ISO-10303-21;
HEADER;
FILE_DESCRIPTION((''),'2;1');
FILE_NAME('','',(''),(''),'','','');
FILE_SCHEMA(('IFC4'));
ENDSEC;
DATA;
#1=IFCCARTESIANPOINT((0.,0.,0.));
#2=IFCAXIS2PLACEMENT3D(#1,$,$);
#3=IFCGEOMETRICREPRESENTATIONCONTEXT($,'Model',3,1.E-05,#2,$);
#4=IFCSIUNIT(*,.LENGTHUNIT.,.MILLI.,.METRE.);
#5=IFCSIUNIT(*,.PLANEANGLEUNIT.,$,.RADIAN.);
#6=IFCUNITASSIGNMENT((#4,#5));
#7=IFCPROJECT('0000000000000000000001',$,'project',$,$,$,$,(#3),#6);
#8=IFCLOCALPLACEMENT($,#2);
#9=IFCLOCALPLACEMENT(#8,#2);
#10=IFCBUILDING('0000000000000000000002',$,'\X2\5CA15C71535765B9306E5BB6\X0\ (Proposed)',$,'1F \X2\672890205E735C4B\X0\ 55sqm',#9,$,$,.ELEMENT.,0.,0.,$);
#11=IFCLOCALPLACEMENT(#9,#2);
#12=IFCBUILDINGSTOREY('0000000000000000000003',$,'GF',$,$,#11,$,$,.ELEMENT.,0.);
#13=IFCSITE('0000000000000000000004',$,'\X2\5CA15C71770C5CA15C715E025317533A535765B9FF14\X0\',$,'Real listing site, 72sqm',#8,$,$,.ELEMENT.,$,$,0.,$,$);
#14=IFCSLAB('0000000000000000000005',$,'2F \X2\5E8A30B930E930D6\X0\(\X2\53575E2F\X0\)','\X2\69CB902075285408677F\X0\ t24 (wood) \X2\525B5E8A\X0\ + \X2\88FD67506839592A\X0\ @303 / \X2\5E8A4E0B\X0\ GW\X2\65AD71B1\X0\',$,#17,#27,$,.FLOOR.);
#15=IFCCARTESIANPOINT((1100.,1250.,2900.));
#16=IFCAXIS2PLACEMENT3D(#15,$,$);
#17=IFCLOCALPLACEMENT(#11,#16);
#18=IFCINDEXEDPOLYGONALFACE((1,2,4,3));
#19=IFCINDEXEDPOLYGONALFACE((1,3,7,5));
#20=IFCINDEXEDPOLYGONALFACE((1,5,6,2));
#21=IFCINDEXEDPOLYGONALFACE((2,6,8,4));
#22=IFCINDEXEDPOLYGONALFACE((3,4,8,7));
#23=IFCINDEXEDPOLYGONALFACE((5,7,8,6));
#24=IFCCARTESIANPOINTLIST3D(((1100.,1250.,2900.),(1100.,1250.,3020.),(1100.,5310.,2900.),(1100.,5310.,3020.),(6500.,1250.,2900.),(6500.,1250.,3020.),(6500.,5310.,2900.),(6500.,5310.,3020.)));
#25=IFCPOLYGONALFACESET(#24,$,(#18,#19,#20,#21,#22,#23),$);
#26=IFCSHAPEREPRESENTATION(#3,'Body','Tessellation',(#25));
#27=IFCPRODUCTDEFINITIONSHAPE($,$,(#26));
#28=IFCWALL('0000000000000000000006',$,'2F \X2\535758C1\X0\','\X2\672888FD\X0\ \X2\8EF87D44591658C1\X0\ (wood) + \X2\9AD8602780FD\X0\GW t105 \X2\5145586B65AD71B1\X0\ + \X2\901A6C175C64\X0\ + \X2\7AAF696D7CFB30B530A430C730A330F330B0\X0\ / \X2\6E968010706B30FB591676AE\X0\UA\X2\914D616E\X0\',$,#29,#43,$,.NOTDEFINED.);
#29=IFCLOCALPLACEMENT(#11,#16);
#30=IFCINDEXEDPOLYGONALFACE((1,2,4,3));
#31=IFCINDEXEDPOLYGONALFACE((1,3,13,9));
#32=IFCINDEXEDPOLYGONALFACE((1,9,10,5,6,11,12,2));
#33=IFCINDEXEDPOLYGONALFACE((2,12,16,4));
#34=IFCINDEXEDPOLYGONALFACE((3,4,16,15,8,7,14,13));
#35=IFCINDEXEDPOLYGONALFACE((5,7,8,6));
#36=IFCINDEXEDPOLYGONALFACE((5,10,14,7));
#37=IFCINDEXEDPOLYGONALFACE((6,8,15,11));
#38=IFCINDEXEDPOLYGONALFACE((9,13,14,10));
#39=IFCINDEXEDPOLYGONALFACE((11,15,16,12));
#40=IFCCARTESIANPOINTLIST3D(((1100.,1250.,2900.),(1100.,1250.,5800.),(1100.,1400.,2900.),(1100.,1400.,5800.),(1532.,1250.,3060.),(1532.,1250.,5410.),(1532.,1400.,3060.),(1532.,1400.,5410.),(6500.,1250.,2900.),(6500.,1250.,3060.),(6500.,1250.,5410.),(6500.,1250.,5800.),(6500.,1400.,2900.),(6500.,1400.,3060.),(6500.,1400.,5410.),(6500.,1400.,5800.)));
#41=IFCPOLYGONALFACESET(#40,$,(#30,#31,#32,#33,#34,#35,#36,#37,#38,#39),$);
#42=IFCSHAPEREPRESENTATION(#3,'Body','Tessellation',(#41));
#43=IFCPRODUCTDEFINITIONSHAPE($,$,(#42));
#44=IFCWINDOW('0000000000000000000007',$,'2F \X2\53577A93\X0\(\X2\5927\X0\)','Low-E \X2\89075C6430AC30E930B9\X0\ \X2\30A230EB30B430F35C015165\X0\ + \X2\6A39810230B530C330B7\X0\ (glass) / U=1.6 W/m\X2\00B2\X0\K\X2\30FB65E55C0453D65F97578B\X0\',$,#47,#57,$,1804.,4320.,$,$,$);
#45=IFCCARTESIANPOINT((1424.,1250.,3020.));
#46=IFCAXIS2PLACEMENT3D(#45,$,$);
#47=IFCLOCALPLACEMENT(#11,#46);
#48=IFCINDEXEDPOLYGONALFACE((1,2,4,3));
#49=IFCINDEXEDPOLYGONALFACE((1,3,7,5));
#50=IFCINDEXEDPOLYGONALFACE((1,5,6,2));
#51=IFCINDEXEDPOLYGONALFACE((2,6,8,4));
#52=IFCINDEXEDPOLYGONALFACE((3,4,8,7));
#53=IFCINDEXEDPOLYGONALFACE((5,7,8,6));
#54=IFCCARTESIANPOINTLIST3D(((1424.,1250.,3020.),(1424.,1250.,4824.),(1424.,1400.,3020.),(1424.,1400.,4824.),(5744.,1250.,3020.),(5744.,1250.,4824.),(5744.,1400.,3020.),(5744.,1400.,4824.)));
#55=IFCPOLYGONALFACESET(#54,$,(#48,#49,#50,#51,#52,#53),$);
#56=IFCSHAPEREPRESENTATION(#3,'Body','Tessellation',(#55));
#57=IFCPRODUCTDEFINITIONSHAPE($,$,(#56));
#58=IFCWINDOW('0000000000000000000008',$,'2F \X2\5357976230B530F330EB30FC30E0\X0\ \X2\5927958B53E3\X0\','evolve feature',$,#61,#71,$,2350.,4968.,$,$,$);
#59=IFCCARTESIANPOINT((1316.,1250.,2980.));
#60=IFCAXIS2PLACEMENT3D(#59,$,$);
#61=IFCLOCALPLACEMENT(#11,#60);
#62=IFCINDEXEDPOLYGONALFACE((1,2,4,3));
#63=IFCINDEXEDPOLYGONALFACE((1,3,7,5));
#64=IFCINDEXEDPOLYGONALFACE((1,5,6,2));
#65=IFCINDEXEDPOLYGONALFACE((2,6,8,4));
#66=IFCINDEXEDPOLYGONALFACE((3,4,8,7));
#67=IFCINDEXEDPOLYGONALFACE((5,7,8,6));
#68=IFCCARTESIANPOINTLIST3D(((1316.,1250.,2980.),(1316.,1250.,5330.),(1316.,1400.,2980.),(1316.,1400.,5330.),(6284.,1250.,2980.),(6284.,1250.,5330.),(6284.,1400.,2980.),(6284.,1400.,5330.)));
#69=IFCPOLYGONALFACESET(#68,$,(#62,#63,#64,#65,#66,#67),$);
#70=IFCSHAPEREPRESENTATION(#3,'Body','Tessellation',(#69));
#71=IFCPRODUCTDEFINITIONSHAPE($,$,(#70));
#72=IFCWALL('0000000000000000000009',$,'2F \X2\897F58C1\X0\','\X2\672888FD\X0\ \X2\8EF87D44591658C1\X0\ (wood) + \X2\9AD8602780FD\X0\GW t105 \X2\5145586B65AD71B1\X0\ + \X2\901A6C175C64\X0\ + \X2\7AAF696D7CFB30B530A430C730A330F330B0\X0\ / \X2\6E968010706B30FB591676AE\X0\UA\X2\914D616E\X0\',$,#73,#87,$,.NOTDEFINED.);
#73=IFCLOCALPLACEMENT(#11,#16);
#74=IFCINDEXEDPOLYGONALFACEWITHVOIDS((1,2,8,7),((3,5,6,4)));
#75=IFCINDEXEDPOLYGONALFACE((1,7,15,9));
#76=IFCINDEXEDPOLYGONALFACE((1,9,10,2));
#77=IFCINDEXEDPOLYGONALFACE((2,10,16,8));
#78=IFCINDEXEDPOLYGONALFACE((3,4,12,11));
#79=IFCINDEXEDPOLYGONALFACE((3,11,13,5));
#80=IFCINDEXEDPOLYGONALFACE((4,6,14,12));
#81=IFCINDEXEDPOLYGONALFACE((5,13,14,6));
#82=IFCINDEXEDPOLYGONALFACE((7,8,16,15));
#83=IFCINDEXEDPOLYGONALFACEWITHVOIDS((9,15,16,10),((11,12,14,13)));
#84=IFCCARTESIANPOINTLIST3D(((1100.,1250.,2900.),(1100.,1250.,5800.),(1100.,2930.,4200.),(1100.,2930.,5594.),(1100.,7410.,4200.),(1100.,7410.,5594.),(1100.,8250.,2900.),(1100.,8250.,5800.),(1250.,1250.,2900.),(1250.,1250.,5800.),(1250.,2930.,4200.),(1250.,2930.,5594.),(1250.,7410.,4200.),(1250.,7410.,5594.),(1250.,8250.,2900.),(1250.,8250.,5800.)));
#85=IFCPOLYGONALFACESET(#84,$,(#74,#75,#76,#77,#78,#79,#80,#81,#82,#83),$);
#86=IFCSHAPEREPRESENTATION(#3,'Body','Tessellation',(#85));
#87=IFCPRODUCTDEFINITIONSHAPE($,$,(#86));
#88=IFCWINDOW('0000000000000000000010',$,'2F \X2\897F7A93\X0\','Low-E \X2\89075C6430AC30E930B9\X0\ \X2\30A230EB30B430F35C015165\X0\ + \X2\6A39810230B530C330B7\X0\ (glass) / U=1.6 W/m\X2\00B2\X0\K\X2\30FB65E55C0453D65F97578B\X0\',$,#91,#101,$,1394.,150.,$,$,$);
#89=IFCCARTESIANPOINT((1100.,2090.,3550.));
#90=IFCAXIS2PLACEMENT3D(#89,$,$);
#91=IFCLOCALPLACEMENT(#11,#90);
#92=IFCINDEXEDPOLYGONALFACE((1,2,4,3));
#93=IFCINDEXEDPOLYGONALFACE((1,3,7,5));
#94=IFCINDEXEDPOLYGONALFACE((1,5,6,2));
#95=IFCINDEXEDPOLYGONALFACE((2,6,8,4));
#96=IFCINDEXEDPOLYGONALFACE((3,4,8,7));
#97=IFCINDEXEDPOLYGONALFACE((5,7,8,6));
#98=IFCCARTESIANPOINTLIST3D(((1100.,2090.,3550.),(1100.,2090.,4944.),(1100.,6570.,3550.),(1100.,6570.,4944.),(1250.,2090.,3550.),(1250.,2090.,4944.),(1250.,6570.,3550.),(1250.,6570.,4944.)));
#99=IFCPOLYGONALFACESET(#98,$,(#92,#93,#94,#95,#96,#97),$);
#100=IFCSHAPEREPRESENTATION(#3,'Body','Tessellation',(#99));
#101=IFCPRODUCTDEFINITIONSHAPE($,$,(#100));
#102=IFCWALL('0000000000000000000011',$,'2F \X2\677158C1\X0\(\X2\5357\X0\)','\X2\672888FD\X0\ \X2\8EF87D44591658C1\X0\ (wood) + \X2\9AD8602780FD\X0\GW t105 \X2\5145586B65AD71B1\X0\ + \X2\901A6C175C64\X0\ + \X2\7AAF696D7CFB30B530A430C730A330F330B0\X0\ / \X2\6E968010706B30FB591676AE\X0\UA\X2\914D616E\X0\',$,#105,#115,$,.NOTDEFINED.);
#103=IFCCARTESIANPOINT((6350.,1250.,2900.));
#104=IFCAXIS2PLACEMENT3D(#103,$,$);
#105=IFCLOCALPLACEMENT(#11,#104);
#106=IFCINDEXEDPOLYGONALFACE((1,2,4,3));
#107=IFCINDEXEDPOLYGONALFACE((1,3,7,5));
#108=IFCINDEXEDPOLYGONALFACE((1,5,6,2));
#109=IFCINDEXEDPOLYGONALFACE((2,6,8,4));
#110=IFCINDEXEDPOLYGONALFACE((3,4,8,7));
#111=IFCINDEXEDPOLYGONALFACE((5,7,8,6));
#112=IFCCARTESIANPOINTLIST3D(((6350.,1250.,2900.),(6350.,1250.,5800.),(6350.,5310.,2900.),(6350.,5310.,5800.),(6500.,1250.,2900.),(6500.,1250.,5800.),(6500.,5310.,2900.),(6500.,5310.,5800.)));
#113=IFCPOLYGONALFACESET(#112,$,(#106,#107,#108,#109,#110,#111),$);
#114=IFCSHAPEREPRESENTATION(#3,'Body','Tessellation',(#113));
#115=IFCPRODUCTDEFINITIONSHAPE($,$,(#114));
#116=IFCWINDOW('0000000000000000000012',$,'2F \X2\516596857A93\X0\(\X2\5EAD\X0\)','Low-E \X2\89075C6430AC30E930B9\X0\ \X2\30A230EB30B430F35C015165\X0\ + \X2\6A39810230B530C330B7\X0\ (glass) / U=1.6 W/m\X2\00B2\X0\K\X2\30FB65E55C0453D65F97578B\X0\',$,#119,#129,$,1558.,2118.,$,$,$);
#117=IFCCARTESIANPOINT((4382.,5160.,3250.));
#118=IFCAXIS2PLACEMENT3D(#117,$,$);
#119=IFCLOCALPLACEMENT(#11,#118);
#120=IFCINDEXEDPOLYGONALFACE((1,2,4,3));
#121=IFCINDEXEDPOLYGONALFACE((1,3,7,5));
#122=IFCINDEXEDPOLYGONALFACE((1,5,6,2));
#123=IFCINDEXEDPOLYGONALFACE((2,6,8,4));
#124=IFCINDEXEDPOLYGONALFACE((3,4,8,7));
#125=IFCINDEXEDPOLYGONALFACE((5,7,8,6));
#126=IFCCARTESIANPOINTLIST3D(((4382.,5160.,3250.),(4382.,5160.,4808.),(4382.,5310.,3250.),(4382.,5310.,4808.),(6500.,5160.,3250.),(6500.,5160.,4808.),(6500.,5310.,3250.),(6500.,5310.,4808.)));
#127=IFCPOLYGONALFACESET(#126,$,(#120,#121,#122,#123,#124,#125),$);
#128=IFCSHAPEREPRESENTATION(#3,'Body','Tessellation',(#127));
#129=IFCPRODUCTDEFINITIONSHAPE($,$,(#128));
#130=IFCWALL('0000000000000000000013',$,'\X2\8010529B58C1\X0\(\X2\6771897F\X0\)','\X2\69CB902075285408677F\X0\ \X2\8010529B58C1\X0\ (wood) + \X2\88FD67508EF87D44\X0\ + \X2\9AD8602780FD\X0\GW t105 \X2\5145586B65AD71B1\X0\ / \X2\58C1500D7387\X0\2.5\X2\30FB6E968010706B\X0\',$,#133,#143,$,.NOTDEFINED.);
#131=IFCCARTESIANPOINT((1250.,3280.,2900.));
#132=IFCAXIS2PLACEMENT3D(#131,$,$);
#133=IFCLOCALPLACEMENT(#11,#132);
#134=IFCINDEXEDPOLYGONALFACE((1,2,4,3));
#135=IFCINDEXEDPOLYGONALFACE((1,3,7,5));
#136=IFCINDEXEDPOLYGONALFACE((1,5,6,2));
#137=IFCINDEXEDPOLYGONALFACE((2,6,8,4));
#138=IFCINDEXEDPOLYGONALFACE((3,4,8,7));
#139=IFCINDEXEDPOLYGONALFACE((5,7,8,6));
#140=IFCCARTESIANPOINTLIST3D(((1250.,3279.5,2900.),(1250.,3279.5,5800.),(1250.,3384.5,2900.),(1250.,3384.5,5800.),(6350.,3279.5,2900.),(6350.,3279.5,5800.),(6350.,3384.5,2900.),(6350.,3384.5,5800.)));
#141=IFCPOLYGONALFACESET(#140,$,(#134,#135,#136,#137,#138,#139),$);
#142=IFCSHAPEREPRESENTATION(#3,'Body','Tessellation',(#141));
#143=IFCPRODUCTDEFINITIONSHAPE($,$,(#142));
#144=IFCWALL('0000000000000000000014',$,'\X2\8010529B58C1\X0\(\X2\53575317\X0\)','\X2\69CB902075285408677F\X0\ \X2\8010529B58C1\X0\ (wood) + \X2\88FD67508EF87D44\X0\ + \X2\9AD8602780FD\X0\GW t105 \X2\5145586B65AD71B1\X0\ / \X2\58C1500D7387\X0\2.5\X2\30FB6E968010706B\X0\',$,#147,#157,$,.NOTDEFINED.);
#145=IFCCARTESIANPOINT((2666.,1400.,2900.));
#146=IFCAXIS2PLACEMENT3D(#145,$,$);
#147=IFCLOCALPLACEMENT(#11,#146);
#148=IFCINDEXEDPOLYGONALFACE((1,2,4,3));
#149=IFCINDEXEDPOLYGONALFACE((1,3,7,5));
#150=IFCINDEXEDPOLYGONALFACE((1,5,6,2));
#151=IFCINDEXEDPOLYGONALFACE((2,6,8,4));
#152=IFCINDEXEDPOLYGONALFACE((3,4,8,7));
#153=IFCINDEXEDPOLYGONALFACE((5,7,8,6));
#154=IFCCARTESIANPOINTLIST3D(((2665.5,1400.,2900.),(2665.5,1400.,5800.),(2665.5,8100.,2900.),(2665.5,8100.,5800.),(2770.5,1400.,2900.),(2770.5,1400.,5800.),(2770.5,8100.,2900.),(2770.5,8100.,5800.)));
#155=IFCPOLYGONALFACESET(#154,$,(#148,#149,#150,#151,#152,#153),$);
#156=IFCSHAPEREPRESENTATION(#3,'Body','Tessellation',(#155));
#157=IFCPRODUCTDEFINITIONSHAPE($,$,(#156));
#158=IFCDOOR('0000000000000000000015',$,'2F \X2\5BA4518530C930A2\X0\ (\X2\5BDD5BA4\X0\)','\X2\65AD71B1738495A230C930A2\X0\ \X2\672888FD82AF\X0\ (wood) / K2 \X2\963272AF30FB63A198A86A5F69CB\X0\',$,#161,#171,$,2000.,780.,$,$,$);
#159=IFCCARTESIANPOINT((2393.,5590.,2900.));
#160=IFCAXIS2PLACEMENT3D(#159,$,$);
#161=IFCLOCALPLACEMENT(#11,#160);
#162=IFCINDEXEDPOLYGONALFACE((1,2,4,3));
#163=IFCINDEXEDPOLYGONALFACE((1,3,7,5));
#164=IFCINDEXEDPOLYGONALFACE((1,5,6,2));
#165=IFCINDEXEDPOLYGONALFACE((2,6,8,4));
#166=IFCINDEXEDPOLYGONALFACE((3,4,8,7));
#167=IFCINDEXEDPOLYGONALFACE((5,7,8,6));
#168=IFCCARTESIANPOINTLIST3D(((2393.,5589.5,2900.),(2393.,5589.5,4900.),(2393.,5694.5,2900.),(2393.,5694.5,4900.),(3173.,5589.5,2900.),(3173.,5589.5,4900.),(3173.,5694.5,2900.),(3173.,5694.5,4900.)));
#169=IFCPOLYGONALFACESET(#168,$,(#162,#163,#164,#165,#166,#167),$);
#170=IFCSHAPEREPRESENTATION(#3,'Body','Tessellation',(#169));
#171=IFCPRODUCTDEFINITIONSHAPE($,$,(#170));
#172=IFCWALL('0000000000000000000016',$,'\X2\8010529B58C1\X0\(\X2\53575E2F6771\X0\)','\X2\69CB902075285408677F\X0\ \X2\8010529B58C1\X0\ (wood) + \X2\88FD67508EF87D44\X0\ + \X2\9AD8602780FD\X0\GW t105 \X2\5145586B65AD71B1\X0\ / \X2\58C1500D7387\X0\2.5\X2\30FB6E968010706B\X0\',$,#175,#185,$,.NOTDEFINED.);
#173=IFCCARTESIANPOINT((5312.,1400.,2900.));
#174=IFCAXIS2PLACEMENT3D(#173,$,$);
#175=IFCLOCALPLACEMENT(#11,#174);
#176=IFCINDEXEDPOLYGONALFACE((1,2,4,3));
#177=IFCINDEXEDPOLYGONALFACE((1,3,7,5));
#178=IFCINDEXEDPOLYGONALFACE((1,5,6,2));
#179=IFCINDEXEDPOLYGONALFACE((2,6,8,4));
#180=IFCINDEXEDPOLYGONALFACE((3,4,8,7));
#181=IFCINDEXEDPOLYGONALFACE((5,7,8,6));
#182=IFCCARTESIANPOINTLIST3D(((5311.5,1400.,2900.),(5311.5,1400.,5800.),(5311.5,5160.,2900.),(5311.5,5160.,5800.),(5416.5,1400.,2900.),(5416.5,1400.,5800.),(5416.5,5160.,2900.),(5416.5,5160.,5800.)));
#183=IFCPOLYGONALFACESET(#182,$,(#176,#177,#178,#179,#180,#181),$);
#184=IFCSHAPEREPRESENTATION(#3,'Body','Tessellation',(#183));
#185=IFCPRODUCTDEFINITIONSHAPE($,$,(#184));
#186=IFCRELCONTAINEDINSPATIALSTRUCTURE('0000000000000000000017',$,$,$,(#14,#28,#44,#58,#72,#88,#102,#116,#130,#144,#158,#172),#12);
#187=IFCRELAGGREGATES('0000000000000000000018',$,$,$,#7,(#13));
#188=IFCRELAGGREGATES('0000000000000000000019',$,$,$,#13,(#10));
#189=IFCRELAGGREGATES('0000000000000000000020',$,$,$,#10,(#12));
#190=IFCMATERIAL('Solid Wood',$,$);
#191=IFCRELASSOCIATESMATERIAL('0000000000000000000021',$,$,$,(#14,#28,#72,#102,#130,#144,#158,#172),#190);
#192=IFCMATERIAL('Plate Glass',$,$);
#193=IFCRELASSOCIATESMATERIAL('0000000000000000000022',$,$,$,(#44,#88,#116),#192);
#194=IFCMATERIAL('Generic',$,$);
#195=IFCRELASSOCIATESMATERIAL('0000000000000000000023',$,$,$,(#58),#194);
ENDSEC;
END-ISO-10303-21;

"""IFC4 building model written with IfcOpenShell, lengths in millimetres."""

from ifc_helpers import new_model, si_unit, frame, frame_2d, origin, place, context, project, spatial, rectangle, extrude, material, element, fill, save


model = new_model("IFC4")

# Units and contexts
model_context = context("Model", 3, precision=1e-05, world=origin())
ifc_project = project(units=[si_unit("LENGTHUNIT", "METRE", prefix="MILLI"), si_unit("PLANEANGLEUNIT", "RADIAN")], contexts=[model_context])

# Site, building, storey
site_placement = place(None, origin())
site = spatial("IfcSite", under=ifc_project, at=site_placement, Name="岡山県岡山市北区南方４", ObjectType="Real listing site, 72sqm", CompositionType="ELEMENT", RefElevation=0.0)
building_placement = place(site_placement, origin())
building = spatial("IfcBuilding", under=site, at=building_placement, Name="岡山南方の家 (Proposed)", ObjectType="1F 木造平屋 55sqm", CompositionType="ELEMENT", ElevationOfRefHeight=0.0, ElevationOfTerrain=0.0)
storey_placement = place(building_placement, origin())
storey = spatial("IfcBuildingStorey", under=building, at=storey_placement, Name="GF", CompositionType="ELEMENT", Elevation=0.0)

# Slab
ifc_material_1 = material(Name="Solid Wood")
slab_placement = place(storey_placement, frame((1100.0, 1250.0, 2900.0)))
element("IfcSlab", 1, at=slab_placement, inside=storey, material=ifc_material_1, Name="2F 床スラブ(南帯)", Description="構造用合板 t24 (wood) 剛床 + 製材根太 @303 / 床下 GW断熱", PredefinedType="FLOOR", context=model_context, shape_type="SweptSolid", body=[
    extrude(rectangle(XDim=5400.0, YDim=4060.0, at=frame_2d((2700.0, 2030.0))), frame((1100.0, 1250.0, 2900.0)), (0.0, 0.0, 1.0), 120.0),
])

# Wall, openings, windows
wall_1_placement = place(storey_placement, frame((1100.0, 1250.0, 2900.0)))
wall_1 = element("IfcWall", 2, at=wall_1_placement, inside=storey, material=ifc_material_1, Name="2F 南壁", Description="木製 軸組外壁 (wood) + 高性能GW t105 充填断熱 + 通気層 + 窯業系サイディング / 準耐火・外皮UA配慮", PredefinedType="NOTDEFINED", context=model_context, shape_type="SweptSolid", body=[
    extrude(rectangle(XDim=5400.0, YDim=150.0, at=frame_2d((2700.0, 75.0))), frame((1100.0, 1250.0, 2900.0)), (0.0, 0.0, 1.0), 2900.0),
])
opening_1_placement = place(storey_placement, frame((1424.0, 1250.0, 3020.0)))
opening_1 = element("IfcOpeningElement", 3, at=opening_1_placement, cuts=wall_1, PredefinedType="NOTDEFINED", context=model_context, shape_type="SweptSolid", body=[
    extrude(rectangle(XDim=4320.0, YDim=150.0, at=frame_2d((2160.0, 75.0))), frame((1424.0, 1250.0, 3020.0)), (0.0, 0.0, 1.0), 1804.0),
])
opening_2_placement = place(storey_placement, frame((1316.0, 1250.0, 2980.0)))
opening_2 = element("IfcOpeningElement", 4, at=opening_2_placement, cuts=wall_1, PredefinedType="NOTDEFINED", context=model_context, shape_type="SweptSolid", body=[
    extrude(rectangle(XDim=4968.0, YDim=150.0, at=frame_2d((2484.0, 75.0))), frame((1316.0, 1250.0, 2980.0)), (0.0, 0.0, 1.0), 2350.0),
])
ifc_material_2 = material(Name="Plate Glass")
window_1_placement = place(storey_placement, frame((1424.0, 1250.0, 3020.0)))
window_1 = element("IfcWindow", 5, at=window_1_placement, inside=storey, material=ifc_material_2, Name="2F 南窓(大)", Description="Low-E 複層ガラス アルゴン封入 + 樹脂サッシ (glass) / U=1.6 W/m²K・日射取得型", OverallHeight=1804.0, OverallWidth=4320.0, context=model_context, shape_type="SweptSolid", body=[
    extrude(rectangle(XDim=4320.0, YDim=150.0, at=frame_2d((2160.0, 75.0))), frame((1424.0, 1250.0, 3020.0)), (0.0, 0.0, 1.0), 1804.0),
])
fill(opening_1, window_1)
ifc_material_3 = material(Name="Generic")
window_2_placement = place(storey_placement, frame((1316.0, 1250.0, 2980.0)))
window_2 = element("IfcWindow", 6, at=window_2_placement, inside=storey, material=ifc_material_3, Name="2F 南面サンルーム 大開口", Description="evolve feature", OverallHeight=2350.0, OverallWidth=4968.0, context=model_context, shape_type="SweptSolid", body=[
    extrude(rectangle(XDim=4968.0, YDim=150.0, at=frame_2d((2484.0, 75.0))), frame((1316.0, 1250.0, 2980.0)), (0.0, 0.0, 1.0), 2350.0),
])
fill(opening_2, window_2)

# Walls, openings, windows
wall_2_placement = place(storey_placement, frame((1100.0, 1250.0, 2900.0)))
wall_2 = element("IfcWall", 7, at=wall_2_placement, inside=storey, material=ifc_material_1, Name="2F 西壁", Description="木製 軸組外壁 (wood) + 高性能GW t105 充填断熱 + 通気層 + 窯業系サイディング / 準耐火・外皮UA配慮", PredefinedType="NOTDEFINED", context=model_context, shape_type="SweptSolid", body=[
    extrude(rectangle(XDim=150.0, YDim=7000.0, at=frame_2d((75.0, 3500.0))), frame((1100.0, 1250.0, 2900.0)), (0.0, 0.0, 1.0), 2900.0),
])
opening_3_placement = place(storey_placement, frame((1100.0, 2090.0, 3550.0)))
opening_3 = element("IfcOpeningElement", 8, at=opening_3_placement, cuts=wall_2, PredefinedType="NOTDEFINED", context=model_context, shape_type="SweptSolid", body=[
    extrude(rectangle(XDim=150.0, YDim=4480.0, at=frame_2d((75.0, 2240.0))), frame((1100.0, 2090.0, 3550.0)), (0.0, 0.0, 1.0), 1394.0),
])
window_3_placement = place(storey_placement, frame((1100.0, 2090.0, 3550.0)))
window_3 = element("IfcWindow", 9, at=window_3_placement, inside=storey, material=ifc_material_2, Name="2F 西窓", Description="Low-E 複層ガラス アルゴン封入 + 樹脂サッシ (glass) / U=1.6 W/m²K・日射取得型", OverallHeight=1394.0, OverallWidth=150.0, context=model_context, shape_type="SweptSolid", body=[
    extrude(rectangle(XDim=150.0, YDim=4480.0, at=frame_2d((75.0, 2240.0))), frame((1100.0, 2090.0, 3550.0)), (0.0, 0.0, 1.0), 1394.0),
])
fill(opening_3, window_3)
wall_3_placement = place(storey_placement, frame((6350.0, 1250.0, 2900.0)))
wall_3 = element("IfcWall", 10, at=wall_3_placement, inside=storey, material=ifc_material_1, Name="2F 東壁(南)", Description="木製 軸組外壁 (wood) + 高性能GW t105 充填断熱 + 通気層 + 窯業系サイディング / 準耐火・外皮UA配慮", PredefinedType="NOTDEFINED", context=model_context, shape_type="SweptSolid", body=[
    extrude(rectangle(XDim=150.0, YDim=4060.0, at=frame_2d((75.0, 2030.0))), frame((6350.0, 1250.0, 2900.0)), (0.0, 0.0, 1.0), 2900.0),
])
opening_4_placement = place(storey_placement, frame((4382.0, 5160.0, 3250.0)))
opening_4 = element("IfcOpeningElement", 11, at=opening_4_placement, cuts=wall_3, PredefinedType="NOTDEFINED", context=model_context, shape_type="SweptSolid", body=[
    extrude(rectangle(XDim=2118.0, YDim=150.0, at=frame_2d((1059.0, 75.0))), frame((4382.0, 5160.0, 3250.0)), (0.0, 0.0, 1.0), 1558.0),
])
window_4_placement = place(storey_placement, frame((4382.0, 5160.0, 3250.0)))
window_4 = element("IfcWindow", 12, at=window_4_placement, inside=storey, material=ifc_material_2, Name="2F 入隅窓(庭)", Description="Low-E 複層ガラス アルゴン封入 + 樹脂サッシ (glass) / U=1.6 W/m²K・日射取得型", OverallHeight=1558.0, OverallWidth=2118.0, context=model_context, shape_type="SweptSolid", body=[
    extrude(rectangle(XDim=2118.0, YDim=150.0, at=frame_2d((1059.0, 75.0))), frame((4382.0, 5160.0, 3250.0)), (0.0, 0.0, 1.0), 1558.0),
])
fill(opening_4, window_4)

# Wall
wall_4_placement = place(storey_placement, frame((1250.0, 3280.0, 2900.0)))
element("IfcWall", 13, at=wall_4_placement, inside=storey, material=ifc_material_1, Name="耐力壁(東西)", Description="構造用合板 耐力壁 (wood) + 製材軸組 + 高性能GW t105 充填断熱 / 壁倍率2.5・準耐火", PredefinedType="NOTDEFINED", context=model_context, shape_type="SweptSolid", body=[
    extrude(rectangle(XDim=5100.0, YDim=105.0, at=frame_2d((2550.0, 52.0))), frame((1250.0, 3280.0, 2900.0)), (0.0, 0.0, 1.0), 2900.0),
])

# Wall, opening, door
wall_5_placement = place(storey_placement, frame((2666.0, 1400.0, 2900.0)))
wall_5 = element("IfcWall", 14, at=wall_5_placement, inside=storey, material=ifc_material_1, Name="耐力壁(南北)", Description="構造用合板 耐力壁 (wood) + 製材軸組 + 高性能GW t105 充填断熱 / 壁倍率2.5・準耐火", PredefinedType="NOTDEFINED", context=model_context, shape_type="SweptSolid", body=[
    extrude(rectangle(XDim=105.0, YDim=6700.0, at=frame_2d((52.0, 3350.0))), frame((2666.0, 1400.0, 2900.0)), (0.0, 0.0, 1.0), 2900.0),
])
opening_5_placement = place(storey_placement, frame((2393.0, 5590.0, 2900.0)))
opening_5 = element("IfcOpeningElement", 15, at=opening_5_placement, cuts=wall_5, PredefinedType="NOTDEFINED", context=model_context, shape_type="SweptSolid", body=[
    extrude(rectangle(XDim=780.0, YDim=105.0, at=frame_2d((390.0, 52.0))), frame((2393.0, 5590.0, 2900.0)), (0.0, 0.0, 1.0), 2000.0),
])
door_placement = place(storey_placement, frame((2393.0, 5590.0, 2900.0)))
door = element("IfcDoor", 16, at=door_placement, inside=storey, material=ifc_material_1, Name="2F 室内ドア (寝室)", Description="断熱玄関ドア 木製芯 (wood) / K2 防犯・採風機構", OverallHeight=2000.0, OverallWidth=780.0, context=model_context, shape_type="SweptSolid", body=[
    extrude(rectangle(XDim=780.0, YDim=105.0, at=frame_2d((390.0, 52.0))), frame((2393.0, 5590.0, 2900.0)), (0.0, 0.0, 1.0), 2000.0),
])
fill(opening_5, door)

# Wall
wall_6_placement = place(storey_placement, frame((5312.0, 1400.0, 2900.0)))
element("IfcWall", 17, at=wall_6_placement, inside=storey, material=ifc_material_1, Name="耐力壁(南帯東)", Description="構造用合板 耐力壁 (wood) + 製材軸組 + 高性能GW t105 充填断熱 / 壁倍率2.5・準耐火", PredefinedType="NOTDEFINED", context=model_context, shape_type="SweptSolid", body=[
    extrude(rectangle(XDim=105.0, YDim=3760.0, at=frame_2d((52.0, 1880.0))), frame((5312.0, 1400.0, 2900.0)), (0.0, 0.0, 1.0), 2900.0),
])

save(model, "model.ifc")
